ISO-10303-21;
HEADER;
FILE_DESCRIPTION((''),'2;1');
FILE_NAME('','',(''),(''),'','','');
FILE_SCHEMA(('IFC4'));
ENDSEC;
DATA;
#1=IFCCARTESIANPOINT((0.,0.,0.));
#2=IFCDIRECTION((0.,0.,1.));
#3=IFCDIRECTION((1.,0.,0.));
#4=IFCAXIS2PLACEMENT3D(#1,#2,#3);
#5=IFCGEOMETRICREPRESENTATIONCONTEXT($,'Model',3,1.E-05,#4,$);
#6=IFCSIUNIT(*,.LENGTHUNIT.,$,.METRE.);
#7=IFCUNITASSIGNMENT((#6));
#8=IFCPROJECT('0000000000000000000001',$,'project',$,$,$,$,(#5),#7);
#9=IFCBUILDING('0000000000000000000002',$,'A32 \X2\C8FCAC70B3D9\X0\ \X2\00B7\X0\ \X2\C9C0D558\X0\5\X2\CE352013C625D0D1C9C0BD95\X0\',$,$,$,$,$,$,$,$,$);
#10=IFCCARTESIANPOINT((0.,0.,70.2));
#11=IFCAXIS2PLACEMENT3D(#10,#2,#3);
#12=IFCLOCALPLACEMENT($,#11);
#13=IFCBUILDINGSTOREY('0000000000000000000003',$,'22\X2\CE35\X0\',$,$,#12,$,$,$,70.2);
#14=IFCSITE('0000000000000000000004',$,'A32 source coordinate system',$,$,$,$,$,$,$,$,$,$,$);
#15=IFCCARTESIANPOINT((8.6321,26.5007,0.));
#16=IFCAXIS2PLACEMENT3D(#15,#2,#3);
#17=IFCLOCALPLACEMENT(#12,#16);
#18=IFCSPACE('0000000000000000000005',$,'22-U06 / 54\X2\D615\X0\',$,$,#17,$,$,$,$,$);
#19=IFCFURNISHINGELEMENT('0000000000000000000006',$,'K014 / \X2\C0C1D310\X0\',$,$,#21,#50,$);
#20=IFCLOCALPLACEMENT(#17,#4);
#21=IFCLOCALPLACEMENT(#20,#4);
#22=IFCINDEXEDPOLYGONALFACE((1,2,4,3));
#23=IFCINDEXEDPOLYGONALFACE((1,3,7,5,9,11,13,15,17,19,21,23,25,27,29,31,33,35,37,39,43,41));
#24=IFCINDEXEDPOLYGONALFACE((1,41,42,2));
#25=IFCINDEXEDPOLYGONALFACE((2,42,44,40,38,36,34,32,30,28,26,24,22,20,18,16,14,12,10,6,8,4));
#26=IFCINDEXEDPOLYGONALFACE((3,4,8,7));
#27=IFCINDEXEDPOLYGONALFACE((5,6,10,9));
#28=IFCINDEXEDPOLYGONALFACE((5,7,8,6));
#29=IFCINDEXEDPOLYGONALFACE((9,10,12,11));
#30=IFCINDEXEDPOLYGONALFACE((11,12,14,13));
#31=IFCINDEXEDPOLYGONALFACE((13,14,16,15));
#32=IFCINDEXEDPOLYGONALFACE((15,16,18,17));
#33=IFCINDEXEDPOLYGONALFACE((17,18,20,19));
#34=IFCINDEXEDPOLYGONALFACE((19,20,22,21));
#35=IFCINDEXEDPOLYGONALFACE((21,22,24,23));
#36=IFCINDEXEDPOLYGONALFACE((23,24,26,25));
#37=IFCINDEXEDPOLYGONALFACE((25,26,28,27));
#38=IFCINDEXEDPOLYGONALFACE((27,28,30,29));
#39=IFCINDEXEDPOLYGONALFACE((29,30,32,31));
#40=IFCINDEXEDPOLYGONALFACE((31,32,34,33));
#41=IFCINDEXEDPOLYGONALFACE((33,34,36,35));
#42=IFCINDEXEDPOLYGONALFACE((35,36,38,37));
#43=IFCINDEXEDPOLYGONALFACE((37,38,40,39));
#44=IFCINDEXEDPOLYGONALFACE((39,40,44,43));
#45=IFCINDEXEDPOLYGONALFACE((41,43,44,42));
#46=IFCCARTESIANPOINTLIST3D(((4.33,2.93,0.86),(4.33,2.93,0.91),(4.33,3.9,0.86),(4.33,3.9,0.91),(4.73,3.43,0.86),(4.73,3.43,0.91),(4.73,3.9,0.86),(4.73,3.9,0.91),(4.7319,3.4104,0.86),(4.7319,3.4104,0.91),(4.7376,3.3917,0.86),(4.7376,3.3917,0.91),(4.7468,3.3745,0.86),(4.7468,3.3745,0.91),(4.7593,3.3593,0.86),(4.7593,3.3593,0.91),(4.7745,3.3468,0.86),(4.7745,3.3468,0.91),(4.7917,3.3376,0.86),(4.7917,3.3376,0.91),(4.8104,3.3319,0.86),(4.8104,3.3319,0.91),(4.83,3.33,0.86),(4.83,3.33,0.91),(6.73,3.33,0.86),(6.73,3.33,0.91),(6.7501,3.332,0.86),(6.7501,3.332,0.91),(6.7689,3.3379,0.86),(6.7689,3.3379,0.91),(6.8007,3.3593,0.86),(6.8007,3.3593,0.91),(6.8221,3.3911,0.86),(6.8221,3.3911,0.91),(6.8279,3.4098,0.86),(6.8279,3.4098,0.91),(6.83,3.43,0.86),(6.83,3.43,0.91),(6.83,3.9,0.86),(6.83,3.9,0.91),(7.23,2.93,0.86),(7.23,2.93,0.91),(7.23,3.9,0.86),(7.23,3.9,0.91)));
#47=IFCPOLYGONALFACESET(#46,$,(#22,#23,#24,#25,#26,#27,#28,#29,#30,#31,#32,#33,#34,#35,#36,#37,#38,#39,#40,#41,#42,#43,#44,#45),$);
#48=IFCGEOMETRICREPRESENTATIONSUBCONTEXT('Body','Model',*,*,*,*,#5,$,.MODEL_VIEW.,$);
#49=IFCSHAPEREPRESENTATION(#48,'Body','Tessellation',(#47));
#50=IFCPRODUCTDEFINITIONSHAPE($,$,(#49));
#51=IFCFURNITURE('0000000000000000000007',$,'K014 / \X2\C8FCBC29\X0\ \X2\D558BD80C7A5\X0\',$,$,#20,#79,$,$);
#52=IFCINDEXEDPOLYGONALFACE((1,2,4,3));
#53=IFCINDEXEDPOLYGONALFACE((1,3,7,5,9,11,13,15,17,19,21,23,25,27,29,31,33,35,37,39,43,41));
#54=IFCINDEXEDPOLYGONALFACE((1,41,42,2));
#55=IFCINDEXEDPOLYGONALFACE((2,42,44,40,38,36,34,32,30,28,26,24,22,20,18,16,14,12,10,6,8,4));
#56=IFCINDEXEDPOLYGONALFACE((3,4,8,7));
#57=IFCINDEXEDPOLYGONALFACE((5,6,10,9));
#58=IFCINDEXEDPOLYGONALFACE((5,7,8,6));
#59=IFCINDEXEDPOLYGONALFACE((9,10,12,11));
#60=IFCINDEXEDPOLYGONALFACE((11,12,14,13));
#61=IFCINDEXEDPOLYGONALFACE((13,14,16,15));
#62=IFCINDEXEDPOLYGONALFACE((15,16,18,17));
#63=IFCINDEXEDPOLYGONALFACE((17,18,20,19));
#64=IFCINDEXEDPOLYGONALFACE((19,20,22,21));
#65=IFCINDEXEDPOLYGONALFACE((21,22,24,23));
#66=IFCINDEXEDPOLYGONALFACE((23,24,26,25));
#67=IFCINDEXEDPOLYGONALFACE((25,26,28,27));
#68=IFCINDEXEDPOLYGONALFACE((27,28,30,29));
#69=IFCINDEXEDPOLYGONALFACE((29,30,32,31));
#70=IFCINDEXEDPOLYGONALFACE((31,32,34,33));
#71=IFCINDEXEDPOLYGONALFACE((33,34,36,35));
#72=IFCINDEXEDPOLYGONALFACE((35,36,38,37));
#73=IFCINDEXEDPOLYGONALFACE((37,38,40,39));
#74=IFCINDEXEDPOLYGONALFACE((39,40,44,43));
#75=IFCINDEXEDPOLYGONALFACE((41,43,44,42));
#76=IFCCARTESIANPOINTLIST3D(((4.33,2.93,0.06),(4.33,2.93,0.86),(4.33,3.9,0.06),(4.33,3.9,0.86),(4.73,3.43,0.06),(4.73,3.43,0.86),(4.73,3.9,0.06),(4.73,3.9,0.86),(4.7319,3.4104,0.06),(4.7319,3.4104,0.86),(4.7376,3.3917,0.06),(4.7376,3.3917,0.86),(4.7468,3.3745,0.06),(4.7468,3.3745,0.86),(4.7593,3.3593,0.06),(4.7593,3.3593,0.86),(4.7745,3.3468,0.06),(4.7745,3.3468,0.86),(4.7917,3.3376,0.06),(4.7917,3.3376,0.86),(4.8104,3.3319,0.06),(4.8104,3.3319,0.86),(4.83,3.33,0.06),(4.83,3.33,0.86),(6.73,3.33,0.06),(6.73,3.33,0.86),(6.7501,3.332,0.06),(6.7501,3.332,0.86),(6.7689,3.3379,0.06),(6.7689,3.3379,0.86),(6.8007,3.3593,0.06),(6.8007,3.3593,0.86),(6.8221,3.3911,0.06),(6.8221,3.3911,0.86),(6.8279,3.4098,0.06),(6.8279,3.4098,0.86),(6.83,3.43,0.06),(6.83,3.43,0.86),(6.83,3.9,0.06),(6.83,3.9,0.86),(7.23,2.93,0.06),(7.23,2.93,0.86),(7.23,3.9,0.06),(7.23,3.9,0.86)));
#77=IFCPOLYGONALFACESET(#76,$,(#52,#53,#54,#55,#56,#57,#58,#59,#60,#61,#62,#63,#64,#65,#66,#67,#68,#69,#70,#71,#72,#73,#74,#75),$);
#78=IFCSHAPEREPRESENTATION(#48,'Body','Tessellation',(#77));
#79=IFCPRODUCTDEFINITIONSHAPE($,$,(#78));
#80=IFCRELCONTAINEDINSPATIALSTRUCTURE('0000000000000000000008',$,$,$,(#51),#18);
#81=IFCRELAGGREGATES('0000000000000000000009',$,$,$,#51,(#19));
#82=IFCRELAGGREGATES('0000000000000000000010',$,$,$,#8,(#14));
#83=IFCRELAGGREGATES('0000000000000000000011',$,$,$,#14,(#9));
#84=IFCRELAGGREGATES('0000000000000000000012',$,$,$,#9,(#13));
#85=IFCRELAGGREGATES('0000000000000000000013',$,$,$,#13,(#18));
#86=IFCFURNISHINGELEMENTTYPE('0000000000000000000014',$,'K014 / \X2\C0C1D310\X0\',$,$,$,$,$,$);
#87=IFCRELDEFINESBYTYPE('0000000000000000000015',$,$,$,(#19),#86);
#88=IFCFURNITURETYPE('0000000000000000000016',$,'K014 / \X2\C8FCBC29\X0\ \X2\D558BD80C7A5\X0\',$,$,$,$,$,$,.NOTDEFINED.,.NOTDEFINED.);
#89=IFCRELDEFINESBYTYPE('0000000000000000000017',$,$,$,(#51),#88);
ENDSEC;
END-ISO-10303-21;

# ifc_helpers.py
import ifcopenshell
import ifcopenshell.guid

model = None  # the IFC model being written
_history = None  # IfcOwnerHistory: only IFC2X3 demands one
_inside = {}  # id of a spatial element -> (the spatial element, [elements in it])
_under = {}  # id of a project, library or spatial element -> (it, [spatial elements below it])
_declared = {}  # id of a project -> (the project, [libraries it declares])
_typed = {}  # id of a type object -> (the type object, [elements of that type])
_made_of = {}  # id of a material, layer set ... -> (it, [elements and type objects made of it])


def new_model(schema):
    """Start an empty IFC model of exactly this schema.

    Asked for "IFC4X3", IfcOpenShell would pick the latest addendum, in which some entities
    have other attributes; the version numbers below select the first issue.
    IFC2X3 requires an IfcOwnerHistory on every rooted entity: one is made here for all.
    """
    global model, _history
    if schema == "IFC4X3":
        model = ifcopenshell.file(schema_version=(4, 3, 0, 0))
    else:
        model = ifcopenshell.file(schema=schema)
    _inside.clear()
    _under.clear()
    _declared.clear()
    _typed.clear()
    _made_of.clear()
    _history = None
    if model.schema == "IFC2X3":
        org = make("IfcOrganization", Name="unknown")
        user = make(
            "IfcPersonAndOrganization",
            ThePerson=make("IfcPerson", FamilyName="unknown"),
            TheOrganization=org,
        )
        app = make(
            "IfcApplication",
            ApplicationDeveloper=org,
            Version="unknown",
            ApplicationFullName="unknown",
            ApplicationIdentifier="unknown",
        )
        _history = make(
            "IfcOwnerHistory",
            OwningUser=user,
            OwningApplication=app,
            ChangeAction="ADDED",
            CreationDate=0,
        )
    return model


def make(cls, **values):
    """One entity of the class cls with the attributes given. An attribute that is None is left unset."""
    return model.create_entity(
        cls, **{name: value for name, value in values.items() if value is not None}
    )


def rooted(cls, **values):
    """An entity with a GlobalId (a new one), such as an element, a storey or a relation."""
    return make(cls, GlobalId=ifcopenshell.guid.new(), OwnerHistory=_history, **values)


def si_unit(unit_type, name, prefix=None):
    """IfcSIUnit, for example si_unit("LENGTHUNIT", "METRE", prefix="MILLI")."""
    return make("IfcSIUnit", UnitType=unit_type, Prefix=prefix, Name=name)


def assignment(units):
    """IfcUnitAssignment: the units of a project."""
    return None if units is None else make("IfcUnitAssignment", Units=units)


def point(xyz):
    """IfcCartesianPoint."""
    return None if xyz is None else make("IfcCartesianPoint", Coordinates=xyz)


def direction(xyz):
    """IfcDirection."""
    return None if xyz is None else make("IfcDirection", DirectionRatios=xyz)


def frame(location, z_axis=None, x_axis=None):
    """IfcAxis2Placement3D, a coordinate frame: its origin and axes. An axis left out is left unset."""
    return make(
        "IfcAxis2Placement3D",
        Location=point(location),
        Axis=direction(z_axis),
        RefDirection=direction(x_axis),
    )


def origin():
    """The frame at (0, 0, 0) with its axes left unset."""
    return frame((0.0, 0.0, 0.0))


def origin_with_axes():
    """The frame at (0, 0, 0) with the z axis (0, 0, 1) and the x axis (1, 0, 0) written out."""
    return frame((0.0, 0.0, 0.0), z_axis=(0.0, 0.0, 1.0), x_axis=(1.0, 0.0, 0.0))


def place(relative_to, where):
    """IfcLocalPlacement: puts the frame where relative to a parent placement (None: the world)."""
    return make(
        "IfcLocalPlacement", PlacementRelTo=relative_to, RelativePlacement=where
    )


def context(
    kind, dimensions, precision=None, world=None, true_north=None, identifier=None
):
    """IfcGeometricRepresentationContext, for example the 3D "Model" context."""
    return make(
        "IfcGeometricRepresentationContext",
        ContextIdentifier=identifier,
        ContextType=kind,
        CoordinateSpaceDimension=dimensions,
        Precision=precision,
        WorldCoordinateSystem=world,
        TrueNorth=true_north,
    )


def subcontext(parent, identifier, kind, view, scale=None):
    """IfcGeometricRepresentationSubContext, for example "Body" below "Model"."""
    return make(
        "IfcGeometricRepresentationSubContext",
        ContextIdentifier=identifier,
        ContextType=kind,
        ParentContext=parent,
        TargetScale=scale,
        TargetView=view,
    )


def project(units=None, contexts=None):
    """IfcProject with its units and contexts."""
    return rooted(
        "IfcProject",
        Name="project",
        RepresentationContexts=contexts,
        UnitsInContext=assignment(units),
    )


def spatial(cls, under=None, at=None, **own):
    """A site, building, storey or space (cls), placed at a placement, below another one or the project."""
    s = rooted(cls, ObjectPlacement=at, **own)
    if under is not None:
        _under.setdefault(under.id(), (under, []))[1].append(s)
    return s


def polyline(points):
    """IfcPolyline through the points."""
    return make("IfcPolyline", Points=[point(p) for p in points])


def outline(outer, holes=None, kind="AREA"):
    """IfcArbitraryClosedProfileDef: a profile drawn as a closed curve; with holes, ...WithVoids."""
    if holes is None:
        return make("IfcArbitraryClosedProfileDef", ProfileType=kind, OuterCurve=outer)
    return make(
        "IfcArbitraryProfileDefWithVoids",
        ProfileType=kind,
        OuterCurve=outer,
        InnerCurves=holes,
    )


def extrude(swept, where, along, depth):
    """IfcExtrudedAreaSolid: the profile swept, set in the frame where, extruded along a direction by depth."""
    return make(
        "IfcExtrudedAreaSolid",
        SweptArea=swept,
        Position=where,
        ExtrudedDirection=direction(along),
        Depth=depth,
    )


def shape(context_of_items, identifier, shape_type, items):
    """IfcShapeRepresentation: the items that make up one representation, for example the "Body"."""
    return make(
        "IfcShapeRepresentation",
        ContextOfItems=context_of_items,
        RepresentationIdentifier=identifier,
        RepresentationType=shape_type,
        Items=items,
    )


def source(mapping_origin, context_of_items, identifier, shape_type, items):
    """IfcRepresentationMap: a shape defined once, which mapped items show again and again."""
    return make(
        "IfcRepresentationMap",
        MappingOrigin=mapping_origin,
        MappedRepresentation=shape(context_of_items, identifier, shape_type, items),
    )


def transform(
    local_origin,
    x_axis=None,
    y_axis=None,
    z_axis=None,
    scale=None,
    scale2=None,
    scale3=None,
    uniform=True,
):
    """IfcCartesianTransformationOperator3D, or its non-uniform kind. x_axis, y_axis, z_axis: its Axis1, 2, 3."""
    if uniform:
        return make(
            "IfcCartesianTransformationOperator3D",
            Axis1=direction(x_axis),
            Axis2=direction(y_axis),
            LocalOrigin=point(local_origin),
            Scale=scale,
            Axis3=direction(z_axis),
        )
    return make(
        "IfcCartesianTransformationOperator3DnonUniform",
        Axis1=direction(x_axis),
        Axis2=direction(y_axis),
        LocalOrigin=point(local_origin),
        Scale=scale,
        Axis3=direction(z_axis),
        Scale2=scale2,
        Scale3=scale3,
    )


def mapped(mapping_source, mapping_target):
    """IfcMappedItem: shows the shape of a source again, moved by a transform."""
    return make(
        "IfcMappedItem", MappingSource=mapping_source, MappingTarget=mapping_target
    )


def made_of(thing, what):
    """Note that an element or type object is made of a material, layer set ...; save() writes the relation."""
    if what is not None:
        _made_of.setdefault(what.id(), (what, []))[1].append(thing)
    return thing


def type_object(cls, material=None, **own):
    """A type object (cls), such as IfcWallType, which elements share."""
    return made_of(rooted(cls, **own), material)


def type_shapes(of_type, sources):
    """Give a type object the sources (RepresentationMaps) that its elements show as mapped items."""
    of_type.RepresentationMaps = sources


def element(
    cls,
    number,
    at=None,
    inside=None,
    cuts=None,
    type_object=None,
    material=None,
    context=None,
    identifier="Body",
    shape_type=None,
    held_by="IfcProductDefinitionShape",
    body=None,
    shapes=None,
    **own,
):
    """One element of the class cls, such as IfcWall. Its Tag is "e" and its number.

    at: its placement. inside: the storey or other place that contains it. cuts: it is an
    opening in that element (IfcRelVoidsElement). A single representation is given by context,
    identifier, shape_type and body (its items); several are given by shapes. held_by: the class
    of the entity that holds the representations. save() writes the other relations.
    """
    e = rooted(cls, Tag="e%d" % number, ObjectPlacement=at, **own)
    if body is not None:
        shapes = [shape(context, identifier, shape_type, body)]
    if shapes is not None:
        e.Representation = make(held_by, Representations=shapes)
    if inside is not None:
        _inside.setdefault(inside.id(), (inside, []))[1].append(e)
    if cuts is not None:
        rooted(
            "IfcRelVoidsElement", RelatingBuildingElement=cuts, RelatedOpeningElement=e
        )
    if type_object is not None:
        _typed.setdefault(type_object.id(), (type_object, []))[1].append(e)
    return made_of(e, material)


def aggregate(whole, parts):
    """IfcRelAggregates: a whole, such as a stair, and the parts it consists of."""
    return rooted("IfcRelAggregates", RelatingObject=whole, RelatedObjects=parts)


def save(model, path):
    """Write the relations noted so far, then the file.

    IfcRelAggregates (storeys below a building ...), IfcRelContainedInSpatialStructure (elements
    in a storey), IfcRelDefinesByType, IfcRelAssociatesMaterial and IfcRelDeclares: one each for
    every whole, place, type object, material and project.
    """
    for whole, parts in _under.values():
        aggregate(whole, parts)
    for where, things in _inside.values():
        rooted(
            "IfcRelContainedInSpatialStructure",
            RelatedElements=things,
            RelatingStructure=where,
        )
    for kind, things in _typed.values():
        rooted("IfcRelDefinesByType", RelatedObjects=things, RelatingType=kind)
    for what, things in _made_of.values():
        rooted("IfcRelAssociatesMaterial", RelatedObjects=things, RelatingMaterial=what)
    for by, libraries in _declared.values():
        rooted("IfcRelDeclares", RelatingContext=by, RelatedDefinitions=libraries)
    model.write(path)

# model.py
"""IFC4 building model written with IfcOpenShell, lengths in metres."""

from ifc_helpers import new_model, si_unit, frame, origin, origin_with_axes, place, context, subcontext, project, spatial, polyline, outline, extrude, source, transform, mapped, type_object, type_shapes, element, aggregate, save


model = new_model("IFC4")

# Units and contexts
model_context = context("Model", 3, precision=1e-05, world=origin_with_axes())
body_context = subcontext(model_context, "Body", "Model", "MODEL_VIEW")
ifc_project = project(units=[si_unit("LENGTHUNIT", "METRE")], contexts=[model_context])

# Site, building, storey, space
site = spatial("IfcSite", under=ifc_project, Name="A32 source coordinate system")
building = spatial("IfcBuilding", under=site, Name="A32 주거동 · 지하5층–옥탑지붕")
storey_placement = place(None, frame((0.0, 0.0, 70.2), z_axis=(0.0, 0.0, 1.0), x_axis=(1.0, 0.0, 0.0)))
storey = spatial("IfcBuildingStorey", under=building, at=storey_placement, Name="22층", Elevation=70.2)
space_placement = place(storey_placement, frame((8.6321, 26.5007, 0.0), z_axis=(0.0, 0.0, 1.0), x_axis=(1.0, 0.0, 0.0)))
space = spatial("IfcSpace", under=storey, at=space_placement, Name="22-U06 / 54형")

# Furnishing element
furnishing_element_type_1 = type_object("IfcFurnishingElementType", Name="K014 / 상판")
shared_shape_1 = source(origin(), body_context, "Body", "SweptSolid", [
    extrude(outline(polyline([(4.33, 2.93), (4.33, 3.9), (4.73, 3.9), (4.73, 3.43), (4.7319, 3.4104), (4.7376, 3.3917), (4.7468, 3.3745), (4.7593, 3.3593), (4.7745, 3.3468), (4.7917, 3.3376), (4.8104, 3.3319), (4.83, 3.33), (6.73, 3.33), (6.7501, 3.332), (6.7689, 3.3379), (6.8007, 3.3593), (6.8221, 3.3911), (6.8279, 3.4098), (6.83, 3.43), (6.83, 3.9), (7.23, 3.9), (7.23, 2.93), (4.33, 2.93)])), frame((0.0, 0.0, 0.86)), (0.0, 0.0, 1.0), 0.05),
])
type_shapes(furnishing_element_type_1, [shared_shape_1])
furniture_1_placement = place(space_placement, origin_with_axes())
furnishing_1_placement = place(furniture_1_placement, origin_with_axes())
furnishing_1 = element("IfcFurnishingElement", 1, at=furnishing_1_placement, type_object=furnishing_element_type_1, Name="K014 / 상판", context=body_context, shape_type="MappedRepresentation", body=[
    mapped(shared_shape_1, transform((0.0, 0.0, 0.0), scale=1.0)),
])

# Furniture
furniture_type_1 = type_object("IfcFurnitureType", Name="K014 / 주방 하부장", AssemblyPlace="NOTDEFINED", PredefinedType="NOTDEFINED")
shared_shape_2 = source(origin(), body_context, "Body", "SweptSolid", [
    extrude(outline(polyline([(7.23, 2.93), (4.33, 2.93), (4.33, 3.9), (4.73, 3.9), (4.73, 3.43), (4.7319, 3.4104), (4.7376, 3.3917), (4.7468, 3.3745), (4.7593, 3.3593), (4.7745, 3.3468), (4.7917, 3.3376), (4.8104, 3.3319), (4.83, 3.33), (6.73, 3.33), (6.7501, 3.332), (6.7689, 3.3379), (6.8007, 3.3593), (6.8221, 3.3911), (6.8279, 3.4098), (6.83, 3.43), (6.83, 3.9), (7.23, 3.9), (7.23, 2.93)])), frame((0.0, 0.0, 0.06)), (0.0, 0.0, 1.0), 0.8),
])
type_shapes(furniture_type_1, [shared_shape_2])
furniture_1 = element("IfcFurniture", 2, at=furniture_1_placement, inside=space, type_object=furniture_type_1, Name="K014 / 주방 하부장", context=body_context, shape_type="MappedRepresentation", body=[
    mapped(shared_shape_2, transform((0.0, 0.0, 0.0), scale=1.0)),
])
aggregate(furniture_1, [furnishing_1])

save(model, "model.ifc")
